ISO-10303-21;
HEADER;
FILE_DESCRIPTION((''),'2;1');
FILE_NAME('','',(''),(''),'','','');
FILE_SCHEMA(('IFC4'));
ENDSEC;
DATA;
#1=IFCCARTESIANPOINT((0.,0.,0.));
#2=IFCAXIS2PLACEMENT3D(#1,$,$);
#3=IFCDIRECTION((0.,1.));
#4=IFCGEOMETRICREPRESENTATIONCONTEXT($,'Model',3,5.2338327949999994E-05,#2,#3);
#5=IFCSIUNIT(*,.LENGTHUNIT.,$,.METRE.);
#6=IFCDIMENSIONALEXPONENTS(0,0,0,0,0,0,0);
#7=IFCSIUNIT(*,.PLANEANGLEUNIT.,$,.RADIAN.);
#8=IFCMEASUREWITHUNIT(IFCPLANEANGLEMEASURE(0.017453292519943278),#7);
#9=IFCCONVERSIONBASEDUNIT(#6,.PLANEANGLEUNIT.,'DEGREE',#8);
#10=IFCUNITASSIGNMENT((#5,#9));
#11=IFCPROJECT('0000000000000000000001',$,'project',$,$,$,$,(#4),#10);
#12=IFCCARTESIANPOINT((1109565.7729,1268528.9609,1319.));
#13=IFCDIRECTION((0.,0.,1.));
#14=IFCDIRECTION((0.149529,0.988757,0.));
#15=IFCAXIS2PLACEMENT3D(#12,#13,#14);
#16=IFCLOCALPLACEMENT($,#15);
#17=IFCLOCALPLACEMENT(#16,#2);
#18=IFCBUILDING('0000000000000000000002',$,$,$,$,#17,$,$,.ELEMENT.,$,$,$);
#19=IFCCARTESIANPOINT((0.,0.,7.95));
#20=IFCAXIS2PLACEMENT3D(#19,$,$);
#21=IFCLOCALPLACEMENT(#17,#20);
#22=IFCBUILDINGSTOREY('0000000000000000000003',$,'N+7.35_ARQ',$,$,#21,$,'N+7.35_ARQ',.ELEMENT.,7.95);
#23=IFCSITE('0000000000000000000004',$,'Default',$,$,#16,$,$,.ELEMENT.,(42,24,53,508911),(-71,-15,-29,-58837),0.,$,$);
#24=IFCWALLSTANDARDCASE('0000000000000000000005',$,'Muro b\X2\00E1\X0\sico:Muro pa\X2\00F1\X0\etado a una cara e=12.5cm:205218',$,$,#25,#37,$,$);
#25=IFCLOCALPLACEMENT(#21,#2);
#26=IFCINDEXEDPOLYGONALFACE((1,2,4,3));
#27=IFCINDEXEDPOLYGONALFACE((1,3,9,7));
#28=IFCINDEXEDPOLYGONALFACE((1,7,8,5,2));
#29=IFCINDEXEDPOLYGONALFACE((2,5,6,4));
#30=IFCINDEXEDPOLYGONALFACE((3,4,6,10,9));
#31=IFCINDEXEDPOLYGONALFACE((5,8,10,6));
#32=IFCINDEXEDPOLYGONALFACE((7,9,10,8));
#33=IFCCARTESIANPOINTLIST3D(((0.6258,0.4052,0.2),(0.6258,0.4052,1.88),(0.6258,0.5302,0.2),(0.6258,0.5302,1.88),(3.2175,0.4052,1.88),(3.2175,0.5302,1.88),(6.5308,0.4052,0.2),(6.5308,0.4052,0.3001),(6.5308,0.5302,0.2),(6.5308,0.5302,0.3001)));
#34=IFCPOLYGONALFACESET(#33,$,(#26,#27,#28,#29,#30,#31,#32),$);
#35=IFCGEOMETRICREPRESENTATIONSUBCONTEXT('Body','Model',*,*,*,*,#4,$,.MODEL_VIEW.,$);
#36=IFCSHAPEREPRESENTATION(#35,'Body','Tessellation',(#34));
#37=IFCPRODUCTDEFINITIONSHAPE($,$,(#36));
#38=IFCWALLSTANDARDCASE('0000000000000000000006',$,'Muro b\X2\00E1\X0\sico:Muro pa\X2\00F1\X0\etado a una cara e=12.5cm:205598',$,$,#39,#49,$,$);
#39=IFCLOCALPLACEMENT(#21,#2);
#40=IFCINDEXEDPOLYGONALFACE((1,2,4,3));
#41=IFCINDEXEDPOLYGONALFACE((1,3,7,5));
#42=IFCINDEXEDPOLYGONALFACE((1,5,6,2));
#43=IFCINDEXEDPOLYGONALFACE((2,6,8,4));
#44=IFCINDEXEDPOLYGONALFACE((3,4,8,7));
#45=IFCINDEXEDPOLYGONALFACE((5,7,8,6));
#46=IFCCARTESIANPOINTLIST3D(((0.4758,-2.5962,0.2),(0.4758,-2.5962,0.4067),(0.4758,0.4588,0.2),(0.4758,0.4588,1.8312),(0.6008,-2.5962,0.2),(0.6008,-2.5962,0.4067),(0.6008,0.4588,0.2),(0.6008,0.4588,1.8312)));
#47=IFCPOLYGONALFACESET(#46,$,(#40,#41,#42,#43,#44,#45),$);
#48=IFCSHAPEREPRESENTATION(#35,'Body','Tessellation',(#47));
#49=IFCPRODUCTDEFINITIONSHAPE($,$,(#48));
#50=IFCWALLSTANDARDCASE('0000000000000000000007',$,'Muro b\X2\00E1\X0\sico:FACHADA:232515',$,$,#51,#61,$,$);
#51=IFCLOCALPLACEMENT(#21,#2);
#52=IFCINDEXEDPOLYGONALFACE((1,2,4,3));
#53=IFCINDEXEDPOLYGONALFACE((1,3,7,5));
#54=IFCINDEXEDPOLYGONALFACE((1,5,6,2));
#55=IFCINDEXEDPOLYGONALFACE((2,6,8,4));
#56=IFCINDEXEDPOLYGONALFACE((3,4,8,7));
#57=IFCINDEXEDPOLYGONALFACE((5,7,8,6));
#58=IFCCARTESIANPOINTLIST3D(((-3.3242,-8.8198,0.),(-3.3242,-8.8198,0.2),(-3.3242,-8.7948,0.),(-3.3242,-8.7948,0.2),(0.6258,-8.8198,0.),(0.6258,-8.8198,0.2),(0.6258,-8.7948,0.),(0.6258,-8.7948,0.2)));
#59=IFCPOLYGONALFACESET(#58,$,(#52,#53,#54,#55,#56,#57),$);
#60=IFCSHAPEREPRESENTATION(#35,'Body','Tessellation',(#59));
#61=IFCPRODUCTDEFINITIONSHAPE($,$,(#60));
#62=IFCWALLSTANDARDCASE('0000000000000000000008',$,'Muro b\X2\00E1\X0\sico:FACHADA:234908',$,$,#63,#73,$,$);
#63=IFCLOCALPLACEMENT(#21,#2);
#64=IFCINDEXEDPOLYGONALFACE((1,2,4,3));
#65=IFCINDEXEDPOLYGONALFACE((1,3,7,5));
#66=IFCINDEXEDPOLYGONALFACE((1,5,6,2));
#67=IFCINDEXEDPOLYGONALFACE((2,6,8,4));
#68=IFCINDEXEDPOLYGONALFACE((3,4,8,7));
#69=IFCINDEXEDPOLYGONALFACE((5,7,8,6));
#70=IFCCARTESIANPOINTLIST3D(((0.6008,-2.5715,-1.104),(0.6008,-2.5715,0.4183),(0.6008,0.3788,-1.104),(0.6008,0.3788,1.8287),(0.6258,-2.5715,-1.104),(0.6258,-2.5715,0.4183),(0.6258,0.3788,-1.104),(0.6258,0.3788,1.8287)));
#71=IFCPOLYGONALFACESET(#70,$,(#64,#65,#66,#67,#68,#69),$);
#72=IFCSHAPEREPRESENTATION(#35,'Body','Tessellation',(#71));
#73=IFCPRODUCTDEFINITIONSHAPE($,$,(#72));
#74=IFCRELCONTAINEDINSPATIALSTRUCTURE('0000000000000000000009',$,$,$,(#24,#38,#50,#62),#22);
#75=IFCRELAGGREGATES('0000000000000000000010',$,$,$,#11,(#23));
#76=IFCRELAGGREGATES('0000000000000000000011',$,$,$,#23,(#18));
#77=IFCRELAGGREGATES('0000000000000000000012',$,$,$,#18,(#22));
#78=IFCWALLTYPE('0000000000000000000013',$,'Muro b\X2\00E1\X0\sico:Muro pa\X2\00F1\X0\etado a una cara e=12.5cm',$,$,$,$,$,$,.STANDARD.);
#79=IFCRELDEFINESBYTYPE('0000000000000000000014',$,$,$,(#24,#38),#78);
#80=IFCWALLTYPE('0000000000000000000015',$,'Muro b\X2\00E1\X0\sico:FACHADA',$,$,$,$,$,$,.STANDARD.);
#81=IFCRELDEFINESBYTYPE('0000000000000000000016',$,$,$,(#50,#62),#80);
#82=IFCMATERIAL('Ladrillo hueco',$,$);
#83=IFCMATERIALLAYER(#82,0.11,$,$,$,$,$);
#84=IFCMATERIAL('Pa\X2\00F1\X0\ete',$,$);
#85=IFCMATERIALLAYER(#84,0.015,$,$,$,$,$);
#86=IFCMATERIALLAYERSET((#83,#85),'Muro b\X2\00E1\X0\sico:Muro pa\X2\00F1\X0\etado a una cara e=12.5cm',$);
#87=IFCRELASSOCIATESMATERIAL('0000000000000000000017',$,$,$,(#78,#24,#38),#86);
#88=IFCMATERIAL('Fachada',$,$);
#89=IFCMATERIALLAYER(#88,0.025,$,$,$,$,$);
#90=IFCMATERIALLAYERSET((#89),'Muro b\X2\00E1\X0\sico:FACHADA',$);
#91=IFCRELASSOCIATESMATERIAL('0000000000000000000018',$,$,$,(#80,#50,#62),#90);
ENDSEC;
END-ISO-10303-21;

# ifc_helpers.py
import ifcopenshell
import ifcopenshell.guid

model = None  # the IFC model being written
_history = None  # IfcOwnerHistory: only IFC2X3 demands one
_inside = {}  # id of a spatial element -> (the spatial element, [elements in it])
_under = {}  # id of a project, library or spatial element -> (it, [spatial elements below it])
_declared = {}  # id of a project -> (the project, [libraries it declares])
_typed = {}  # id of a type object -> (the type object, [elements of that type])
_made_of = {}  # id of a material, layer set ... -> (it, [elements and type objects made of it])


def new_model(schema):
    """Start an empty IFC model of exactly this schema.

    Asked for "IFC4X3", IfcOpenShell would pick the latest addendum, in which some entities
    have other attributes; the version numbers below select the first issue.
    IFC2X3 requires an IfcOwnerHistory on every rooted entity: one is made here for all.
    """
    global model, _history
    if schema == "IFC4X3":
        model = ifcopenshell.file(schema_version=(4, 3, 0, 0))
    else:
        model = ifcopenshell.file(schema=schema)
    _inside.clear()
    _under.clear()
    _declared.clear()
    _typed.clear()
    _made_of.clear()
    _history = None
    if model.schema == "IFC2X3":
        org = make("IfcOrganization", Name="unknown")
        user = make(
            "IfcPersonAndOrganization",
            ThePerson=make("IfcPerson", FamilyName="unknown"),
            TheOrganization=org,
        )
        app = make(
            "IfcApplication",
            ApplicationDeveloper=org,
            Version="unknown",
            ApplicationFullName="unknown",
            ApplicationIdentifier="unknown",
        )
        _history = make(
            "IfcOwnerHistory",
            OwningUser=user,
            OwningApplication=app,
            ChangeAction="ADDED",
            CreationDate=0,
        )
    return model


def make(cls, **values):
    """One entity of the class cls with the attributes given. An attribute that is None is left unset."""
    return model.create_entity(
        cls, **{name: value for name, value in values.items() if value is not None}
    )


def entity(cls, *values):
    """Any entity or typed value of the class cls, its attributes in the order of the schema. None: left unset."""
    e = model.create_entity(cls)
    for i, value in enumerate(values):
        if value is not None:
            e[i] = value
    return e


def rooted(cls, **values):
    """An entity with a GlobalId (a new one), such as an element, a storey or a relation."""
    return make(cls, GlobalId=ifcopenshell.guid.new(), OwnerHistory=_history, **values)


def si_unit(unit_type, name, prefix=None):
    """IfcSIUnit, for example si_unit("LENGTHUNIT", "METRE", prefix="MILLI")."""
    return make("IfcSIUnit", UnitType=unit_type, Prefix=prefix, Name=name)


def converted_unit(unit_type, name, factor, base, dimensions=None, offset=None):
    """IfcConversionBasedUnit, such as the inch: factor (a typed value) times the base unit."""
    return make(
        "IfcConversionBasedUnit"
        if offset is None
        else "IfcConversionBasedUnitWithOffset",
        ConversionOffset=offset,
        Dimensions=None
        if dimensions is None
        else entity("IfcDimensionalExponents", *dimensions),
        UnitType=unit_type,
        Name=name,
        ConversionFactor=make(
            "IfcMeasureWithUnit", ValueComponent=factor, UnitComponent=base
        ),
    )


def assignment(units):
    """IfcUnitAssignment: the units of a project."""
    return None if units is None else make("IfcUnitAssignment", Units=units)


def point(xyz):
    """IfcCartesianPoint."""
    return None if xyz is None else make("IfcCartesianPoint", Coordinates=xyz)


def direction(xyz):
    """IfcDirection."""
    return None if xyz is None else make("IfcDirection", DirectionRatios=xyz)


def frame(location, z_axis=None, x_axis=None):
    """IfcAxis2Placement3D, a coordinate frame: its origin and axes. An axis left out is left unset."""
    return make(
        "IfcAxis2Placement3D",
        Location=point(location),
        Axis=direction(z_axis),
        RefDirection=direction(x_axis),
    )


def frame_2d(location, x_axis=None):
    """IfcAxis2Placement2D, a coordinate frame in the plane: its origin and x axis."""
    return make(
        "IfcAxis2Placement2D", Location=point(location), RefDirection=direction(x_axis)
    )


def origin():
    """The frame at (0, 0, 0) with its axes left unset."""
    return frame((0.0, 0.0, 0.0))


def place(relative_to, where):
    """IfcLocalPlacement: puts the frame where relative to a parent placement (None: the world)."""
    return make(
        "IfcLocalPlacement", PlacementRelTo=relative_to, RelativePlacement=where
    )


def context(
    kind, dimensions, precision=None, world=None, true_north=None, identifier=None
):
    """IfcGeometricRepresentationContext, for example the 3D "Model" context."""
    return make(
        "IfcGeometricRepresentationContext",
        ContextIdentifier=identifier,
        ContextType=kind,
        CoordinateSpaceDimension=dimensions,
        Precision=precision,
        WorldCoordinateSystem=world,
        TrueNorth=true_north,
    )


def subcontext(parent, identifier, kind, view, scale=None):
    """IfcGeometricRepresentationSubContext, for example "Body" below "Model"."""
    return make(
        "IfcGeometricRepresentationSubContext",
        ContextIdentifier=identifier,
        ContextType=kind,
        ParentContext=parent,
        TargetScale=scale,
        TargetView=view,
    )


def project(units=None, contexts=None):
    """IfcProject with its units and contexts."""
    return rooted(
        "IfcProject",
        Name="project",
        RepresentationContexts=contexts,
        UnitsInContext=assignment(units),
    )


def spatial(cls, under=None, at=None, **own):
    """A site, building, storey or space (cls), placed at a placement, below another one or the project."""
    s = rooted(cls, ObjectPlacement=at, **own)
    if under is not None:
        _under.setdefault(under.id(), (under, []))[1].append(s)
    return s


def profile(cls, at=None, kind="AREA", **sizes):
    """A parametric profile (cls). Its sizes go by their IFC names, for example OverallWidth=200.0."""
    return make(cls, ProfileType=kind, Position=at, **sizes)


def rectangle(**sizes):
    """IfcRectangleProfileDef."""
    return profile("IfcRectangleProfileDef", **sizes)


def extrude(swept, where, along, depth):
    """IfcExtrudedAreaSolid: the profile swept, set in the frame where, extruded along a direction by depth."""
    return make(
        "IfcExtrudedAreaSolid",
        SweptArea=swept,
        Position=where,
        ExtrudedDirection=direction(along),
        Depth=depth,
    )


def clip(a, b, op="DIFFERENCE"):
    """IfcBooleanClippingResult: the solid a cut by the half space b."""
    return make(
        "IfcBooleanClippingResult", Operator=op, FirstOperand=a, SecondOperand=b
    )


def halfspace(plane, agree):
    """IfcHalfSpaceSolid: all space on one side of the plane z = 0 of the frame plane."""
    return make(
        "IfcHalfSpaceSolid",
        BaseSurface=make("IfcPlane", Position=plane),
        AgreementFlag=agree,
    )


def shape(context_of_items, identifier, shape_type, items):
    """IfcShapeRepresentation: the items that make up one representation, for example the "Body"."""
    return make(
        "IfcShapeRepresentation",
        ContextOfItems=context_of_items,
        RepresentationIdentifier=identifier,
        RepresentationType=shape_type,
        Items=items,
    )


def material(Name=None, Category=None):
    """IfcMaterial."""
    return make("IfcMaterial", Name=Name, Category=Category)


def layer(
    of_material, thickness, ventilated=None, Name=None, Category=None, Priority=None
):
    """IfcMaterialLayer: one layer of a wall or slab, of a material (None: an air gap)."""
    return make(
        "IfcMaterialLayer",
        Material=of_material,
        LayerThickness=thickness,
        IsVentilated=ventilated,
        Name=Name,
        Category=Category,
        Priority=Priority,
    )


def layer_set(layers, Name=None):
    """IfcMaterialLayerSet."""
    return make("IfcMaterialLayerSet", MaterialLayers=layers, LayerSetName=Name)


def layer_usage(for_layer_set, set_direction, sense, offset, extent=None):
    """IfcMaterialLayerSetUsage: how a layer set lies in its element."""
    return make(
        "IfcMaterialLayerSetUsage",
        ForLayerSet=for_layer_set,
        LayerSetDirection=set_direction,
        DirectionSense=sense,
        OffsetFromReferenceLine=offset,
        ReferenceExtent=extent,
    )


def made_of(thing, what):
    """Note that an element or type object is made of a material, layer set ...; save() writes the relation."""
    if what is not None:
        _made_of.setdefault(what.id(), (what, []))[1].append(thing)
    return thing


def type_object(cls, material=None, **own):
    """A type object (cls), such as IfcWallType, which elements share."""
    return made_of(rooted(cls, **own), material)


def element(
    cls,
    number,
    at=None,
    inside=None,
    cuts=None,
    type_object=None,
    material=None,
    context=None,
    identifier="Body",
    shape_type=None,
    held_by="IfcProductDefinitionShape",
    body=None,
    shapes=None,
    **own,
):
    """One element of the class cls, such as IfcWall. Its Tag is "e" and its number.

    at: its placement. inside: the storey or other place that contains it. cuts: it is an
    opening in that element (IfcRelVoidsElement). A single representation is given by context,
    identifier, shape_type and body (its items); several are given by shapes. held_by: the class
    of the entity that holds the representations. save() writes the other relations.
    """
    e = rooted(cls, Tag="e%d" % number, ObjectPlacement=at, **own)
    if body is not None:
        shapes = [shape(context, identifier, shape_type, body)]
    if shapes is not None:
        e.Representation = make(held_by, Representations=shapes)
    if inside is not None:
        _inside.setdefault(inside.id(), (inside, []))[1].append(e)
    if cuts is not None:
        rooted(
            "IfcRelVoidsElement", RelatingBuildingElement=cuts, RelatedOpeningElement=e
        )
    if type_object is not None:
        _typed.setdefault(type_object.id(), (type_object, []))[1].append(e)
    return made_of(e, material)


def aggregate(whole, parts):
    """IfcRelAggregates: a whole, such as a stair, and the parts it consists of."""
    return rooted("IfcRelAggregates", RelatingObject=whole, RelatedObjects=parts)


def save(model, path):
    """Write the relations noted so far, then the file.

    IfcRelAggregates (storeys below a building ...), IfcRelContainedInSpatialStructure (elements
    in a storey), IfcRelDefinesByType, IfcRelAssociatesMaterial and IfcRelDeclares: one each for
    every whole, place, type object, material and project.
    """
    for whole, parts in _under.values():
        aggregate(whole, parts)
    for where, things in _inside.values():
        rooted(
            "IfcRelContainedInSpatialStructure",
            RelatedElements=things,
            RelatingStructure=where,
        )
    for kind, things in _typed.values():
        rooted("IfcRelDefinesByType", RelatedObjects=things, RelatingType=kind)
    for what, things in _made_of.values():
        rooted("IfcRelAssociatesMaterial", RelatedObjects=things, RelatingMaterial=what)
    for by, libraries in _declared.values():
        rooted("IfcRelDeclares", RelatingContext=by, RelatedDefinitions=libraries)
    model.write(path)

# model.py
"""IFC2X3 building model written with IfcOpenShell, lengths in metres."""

from ifc_helpers import new_model, entity, si_unit, converted_unit, direction, frame, frame_2d, origin, place, context, subcontext, project, spatial, rectangle, extrude, clip, halfspace, material, layer, layer_set, layer_usage, type_object, element, save


model = new_model("IFC2X3")

# Units and contexts
model_context = context("Model", 3, precision=5.2338327949999994e-05, world=origin(), true_north=direction((0.0, 1.0)))
body_context = subcontext(model_context, "Body", "Model", "MODEL_VIEW")
ifc_project = project(units=[si_unit("LENGTHUNIT", "METRE"), converted_unit("PLANEANGLEUNIT", "DEGREE", entity("IfcPlaneAngleMeasure", 0.017453292519943278), si_unit("PLANEANGLEUNIT", "RADIAN"), dimensions=[0, 0, 0, 0, 0, 0, 0])], contexts=[model_context])

# Site, building, storey
site_placement = place(None, frame((1109565.7729, 1268528.9609, 1319.0), z_axis=(0.0, 0.0, 1.0), x_axis=(0.149529, 0.988757, 0.0)))
site = spatial("IfcSite", under=ifc_project, at=site_placement, Name="Default", CompositionType="ELEMENT", RefLatitude=(42, 24, 53, 508911), RefLongitude=(-71, -15, -29, -58837), RefElevation=0.0)
building_placement = place(site_placement, origin())
building = spatial("IfcBuilding", under=site, at=building_placement, CompositionType="ELEMENT")
storey_placement = place(building_placement, frame((0.0, 0.0, 7.95)))
storey = spatial("IfcBuildingStorey", under=building, at=storey_placement, Name="N+7.35_ARQ", LongName="N+7.35_ARQ", CompositionType="ELEMENT", Elevation=7.95)

# Walls
ifc_material_1 = material(Name="Ladrillo hueco")
ifc_layer_1 = layer(ifc_material_1, 0.11)
ifc_material_2 = material(Name="Pañete")
ifc_layer_2 = layer(ifc_material_2, 0.015)
ifc_layer_set_1 = layer_set([ifc_layer_1, ifc_layer_2], Name="Muro básico:Muro pañetado a una cara e=12.5cm")
ifc_layer_usage_1 = layer_usage(ifc_layer_set_1, "AXIS2", "NEGATIVE", 0.0625)
wall_type_1 = type_object("IfcWallType", Name="Muro básico:Muro pañetado a una cara e=12.5cm", PredefinedType="STANDARD", material=ifc_layer_set_1)
wall_1_placement = place(storey_placement, frame((6.5308, 0.4677, 0.2), z_axis=(0.0, 0.0, 1.0), x_axis=(-1.0, 0.0, 0.0)))
element("IfcWallStandardCase", 1, at=wall_1_placement, inside=storey, type_object=wall_type_1, material=ifc_layer_usage_1, Name="Muro básico:Muro pañetado a una cara e=12.5cm:205218", context=body_context, shape_type="Clipping", body=[
    clip(clip(extrude(rectangle(XDim=5.905, YDim=0.125, at=frame_2d((2.9525, 0.0), x_axis=(-1.0, 0.0))), origin(), (0.0, 0.0, 1.0), 1.68), halfspace(frame((0.0, -0.0625, 0.1001), z_axis=(-0.430421, 0.0, 0.902628), x_axis=(0.0, 1.0, 0.0)), False)), halfspace(frame((3.3132, -0.0625, 1.68), z_axis=(0.0, 0.0, 1.0), x_axis=(0.0, 1.0, 0.0)), False)),
])
ifc_layer_usage_2 = layer_usage(ifc_layer_set_1, "AXIS2", "NEGATIVE", 0.0625)
wall_2_placement = place(storey_placement, frame((0.5383, 0.4588, 0.2), z_axis=(0.0, 0.0, 1.0), x_axis=(0.0, -1.0, 0.0)))
element("IfcWallStandardCase", 2, at=wall_2_placement, inside=storey, type_object=wall_type_1, material=ifc_layer_usage_2, Name="Muro básico:Muro pañetado a una cara e=12.5cm:205598", context=body_context, shape_type="Clipping", body=[
    clip(extrude(rectangle(XDim=3.055, YDim=0.125, at=frame_2d((1.5275, 0.0), x_axis=(-1.0, 0.0))), origin(), (0.0, 0.0, 1.0), 1.6312), halfspace(frame((0.0, -0.0625, 1.6312), z_axis=(0.422613, 0.0, 0.90631), x_axis=(0.0, 1.0, 0.0)), False)),
])
ifc_material_3 = material(Name="Fachada")
ifc_layer_3 = layer(ifc_material_3, 0.025)
ifc_layer_set_2 = layer_set([ifc_layer_3], Name="Muro básico:FACHADA")
ifc_layer_usage_3 = layer_usage(ifc_layer_set_2, "AXIS2", "POSITIVE", -0.0125)
wall_type_2 = type_object("IfcWallType", Name="Muro básico:FACHADA", PredefinedType="STANDARD", material=ifc_layer_set_2)
wall_3_placement = place(storey_placement, frame((-3.3242, -8.8073, 0.0)))
element("IfcWallStandardCase", 3, at=wall_3_placement, inside=storey, type_object=wall_type_2, material=ifc_layer_usage_3, Name="Muro básico:FACHADA:232515", context=body_context, shape_type="SweptSolid", body=[
    extrude(rectangle(XDim=3.95, YDim=0.025, at=frame_2d((1.975, 0.0), x_axis=(-1.0, 0.0))), origin(), (0.0, 0.0, 1.0), 0.2),
])
ifc_layer_usage_4 = layer_usage(ifc_layer_set_2, "AXIS2", "POSITIVE", -0.0125)
wall_4_placement = place(storey_placement, frame((0.6133, -2.5715, -1.104), z_axis=(0.0, 0.0, 1.0), x_axis=(0.0, 1.0, 0.0)))
element("IfcWallStandardCase", 4, at=wall_4_placement, inside=storey, type_object=wall_type_2, material=ifc_layer_usage_4, Name="Muro básico:FACHADA:234908", context=body_context, shape_type="Clipping", body=[
    clip(extrude(rectangle(XDim=2.9503, YDim=0.025, at=frame_2d((1.4751, 0.0), x_axis=(-1.0, 0.0))), origin(), (0.0, 0.0, 1.0), 2.9327), halfspace(frame((0.0, -0.0125, 1.5223), z_axis=(-0.431304, 0.0, 0.902207), x_axis=(0.0, 1.0, 0.0)), False)),
])

save(model, "model.ifc")
